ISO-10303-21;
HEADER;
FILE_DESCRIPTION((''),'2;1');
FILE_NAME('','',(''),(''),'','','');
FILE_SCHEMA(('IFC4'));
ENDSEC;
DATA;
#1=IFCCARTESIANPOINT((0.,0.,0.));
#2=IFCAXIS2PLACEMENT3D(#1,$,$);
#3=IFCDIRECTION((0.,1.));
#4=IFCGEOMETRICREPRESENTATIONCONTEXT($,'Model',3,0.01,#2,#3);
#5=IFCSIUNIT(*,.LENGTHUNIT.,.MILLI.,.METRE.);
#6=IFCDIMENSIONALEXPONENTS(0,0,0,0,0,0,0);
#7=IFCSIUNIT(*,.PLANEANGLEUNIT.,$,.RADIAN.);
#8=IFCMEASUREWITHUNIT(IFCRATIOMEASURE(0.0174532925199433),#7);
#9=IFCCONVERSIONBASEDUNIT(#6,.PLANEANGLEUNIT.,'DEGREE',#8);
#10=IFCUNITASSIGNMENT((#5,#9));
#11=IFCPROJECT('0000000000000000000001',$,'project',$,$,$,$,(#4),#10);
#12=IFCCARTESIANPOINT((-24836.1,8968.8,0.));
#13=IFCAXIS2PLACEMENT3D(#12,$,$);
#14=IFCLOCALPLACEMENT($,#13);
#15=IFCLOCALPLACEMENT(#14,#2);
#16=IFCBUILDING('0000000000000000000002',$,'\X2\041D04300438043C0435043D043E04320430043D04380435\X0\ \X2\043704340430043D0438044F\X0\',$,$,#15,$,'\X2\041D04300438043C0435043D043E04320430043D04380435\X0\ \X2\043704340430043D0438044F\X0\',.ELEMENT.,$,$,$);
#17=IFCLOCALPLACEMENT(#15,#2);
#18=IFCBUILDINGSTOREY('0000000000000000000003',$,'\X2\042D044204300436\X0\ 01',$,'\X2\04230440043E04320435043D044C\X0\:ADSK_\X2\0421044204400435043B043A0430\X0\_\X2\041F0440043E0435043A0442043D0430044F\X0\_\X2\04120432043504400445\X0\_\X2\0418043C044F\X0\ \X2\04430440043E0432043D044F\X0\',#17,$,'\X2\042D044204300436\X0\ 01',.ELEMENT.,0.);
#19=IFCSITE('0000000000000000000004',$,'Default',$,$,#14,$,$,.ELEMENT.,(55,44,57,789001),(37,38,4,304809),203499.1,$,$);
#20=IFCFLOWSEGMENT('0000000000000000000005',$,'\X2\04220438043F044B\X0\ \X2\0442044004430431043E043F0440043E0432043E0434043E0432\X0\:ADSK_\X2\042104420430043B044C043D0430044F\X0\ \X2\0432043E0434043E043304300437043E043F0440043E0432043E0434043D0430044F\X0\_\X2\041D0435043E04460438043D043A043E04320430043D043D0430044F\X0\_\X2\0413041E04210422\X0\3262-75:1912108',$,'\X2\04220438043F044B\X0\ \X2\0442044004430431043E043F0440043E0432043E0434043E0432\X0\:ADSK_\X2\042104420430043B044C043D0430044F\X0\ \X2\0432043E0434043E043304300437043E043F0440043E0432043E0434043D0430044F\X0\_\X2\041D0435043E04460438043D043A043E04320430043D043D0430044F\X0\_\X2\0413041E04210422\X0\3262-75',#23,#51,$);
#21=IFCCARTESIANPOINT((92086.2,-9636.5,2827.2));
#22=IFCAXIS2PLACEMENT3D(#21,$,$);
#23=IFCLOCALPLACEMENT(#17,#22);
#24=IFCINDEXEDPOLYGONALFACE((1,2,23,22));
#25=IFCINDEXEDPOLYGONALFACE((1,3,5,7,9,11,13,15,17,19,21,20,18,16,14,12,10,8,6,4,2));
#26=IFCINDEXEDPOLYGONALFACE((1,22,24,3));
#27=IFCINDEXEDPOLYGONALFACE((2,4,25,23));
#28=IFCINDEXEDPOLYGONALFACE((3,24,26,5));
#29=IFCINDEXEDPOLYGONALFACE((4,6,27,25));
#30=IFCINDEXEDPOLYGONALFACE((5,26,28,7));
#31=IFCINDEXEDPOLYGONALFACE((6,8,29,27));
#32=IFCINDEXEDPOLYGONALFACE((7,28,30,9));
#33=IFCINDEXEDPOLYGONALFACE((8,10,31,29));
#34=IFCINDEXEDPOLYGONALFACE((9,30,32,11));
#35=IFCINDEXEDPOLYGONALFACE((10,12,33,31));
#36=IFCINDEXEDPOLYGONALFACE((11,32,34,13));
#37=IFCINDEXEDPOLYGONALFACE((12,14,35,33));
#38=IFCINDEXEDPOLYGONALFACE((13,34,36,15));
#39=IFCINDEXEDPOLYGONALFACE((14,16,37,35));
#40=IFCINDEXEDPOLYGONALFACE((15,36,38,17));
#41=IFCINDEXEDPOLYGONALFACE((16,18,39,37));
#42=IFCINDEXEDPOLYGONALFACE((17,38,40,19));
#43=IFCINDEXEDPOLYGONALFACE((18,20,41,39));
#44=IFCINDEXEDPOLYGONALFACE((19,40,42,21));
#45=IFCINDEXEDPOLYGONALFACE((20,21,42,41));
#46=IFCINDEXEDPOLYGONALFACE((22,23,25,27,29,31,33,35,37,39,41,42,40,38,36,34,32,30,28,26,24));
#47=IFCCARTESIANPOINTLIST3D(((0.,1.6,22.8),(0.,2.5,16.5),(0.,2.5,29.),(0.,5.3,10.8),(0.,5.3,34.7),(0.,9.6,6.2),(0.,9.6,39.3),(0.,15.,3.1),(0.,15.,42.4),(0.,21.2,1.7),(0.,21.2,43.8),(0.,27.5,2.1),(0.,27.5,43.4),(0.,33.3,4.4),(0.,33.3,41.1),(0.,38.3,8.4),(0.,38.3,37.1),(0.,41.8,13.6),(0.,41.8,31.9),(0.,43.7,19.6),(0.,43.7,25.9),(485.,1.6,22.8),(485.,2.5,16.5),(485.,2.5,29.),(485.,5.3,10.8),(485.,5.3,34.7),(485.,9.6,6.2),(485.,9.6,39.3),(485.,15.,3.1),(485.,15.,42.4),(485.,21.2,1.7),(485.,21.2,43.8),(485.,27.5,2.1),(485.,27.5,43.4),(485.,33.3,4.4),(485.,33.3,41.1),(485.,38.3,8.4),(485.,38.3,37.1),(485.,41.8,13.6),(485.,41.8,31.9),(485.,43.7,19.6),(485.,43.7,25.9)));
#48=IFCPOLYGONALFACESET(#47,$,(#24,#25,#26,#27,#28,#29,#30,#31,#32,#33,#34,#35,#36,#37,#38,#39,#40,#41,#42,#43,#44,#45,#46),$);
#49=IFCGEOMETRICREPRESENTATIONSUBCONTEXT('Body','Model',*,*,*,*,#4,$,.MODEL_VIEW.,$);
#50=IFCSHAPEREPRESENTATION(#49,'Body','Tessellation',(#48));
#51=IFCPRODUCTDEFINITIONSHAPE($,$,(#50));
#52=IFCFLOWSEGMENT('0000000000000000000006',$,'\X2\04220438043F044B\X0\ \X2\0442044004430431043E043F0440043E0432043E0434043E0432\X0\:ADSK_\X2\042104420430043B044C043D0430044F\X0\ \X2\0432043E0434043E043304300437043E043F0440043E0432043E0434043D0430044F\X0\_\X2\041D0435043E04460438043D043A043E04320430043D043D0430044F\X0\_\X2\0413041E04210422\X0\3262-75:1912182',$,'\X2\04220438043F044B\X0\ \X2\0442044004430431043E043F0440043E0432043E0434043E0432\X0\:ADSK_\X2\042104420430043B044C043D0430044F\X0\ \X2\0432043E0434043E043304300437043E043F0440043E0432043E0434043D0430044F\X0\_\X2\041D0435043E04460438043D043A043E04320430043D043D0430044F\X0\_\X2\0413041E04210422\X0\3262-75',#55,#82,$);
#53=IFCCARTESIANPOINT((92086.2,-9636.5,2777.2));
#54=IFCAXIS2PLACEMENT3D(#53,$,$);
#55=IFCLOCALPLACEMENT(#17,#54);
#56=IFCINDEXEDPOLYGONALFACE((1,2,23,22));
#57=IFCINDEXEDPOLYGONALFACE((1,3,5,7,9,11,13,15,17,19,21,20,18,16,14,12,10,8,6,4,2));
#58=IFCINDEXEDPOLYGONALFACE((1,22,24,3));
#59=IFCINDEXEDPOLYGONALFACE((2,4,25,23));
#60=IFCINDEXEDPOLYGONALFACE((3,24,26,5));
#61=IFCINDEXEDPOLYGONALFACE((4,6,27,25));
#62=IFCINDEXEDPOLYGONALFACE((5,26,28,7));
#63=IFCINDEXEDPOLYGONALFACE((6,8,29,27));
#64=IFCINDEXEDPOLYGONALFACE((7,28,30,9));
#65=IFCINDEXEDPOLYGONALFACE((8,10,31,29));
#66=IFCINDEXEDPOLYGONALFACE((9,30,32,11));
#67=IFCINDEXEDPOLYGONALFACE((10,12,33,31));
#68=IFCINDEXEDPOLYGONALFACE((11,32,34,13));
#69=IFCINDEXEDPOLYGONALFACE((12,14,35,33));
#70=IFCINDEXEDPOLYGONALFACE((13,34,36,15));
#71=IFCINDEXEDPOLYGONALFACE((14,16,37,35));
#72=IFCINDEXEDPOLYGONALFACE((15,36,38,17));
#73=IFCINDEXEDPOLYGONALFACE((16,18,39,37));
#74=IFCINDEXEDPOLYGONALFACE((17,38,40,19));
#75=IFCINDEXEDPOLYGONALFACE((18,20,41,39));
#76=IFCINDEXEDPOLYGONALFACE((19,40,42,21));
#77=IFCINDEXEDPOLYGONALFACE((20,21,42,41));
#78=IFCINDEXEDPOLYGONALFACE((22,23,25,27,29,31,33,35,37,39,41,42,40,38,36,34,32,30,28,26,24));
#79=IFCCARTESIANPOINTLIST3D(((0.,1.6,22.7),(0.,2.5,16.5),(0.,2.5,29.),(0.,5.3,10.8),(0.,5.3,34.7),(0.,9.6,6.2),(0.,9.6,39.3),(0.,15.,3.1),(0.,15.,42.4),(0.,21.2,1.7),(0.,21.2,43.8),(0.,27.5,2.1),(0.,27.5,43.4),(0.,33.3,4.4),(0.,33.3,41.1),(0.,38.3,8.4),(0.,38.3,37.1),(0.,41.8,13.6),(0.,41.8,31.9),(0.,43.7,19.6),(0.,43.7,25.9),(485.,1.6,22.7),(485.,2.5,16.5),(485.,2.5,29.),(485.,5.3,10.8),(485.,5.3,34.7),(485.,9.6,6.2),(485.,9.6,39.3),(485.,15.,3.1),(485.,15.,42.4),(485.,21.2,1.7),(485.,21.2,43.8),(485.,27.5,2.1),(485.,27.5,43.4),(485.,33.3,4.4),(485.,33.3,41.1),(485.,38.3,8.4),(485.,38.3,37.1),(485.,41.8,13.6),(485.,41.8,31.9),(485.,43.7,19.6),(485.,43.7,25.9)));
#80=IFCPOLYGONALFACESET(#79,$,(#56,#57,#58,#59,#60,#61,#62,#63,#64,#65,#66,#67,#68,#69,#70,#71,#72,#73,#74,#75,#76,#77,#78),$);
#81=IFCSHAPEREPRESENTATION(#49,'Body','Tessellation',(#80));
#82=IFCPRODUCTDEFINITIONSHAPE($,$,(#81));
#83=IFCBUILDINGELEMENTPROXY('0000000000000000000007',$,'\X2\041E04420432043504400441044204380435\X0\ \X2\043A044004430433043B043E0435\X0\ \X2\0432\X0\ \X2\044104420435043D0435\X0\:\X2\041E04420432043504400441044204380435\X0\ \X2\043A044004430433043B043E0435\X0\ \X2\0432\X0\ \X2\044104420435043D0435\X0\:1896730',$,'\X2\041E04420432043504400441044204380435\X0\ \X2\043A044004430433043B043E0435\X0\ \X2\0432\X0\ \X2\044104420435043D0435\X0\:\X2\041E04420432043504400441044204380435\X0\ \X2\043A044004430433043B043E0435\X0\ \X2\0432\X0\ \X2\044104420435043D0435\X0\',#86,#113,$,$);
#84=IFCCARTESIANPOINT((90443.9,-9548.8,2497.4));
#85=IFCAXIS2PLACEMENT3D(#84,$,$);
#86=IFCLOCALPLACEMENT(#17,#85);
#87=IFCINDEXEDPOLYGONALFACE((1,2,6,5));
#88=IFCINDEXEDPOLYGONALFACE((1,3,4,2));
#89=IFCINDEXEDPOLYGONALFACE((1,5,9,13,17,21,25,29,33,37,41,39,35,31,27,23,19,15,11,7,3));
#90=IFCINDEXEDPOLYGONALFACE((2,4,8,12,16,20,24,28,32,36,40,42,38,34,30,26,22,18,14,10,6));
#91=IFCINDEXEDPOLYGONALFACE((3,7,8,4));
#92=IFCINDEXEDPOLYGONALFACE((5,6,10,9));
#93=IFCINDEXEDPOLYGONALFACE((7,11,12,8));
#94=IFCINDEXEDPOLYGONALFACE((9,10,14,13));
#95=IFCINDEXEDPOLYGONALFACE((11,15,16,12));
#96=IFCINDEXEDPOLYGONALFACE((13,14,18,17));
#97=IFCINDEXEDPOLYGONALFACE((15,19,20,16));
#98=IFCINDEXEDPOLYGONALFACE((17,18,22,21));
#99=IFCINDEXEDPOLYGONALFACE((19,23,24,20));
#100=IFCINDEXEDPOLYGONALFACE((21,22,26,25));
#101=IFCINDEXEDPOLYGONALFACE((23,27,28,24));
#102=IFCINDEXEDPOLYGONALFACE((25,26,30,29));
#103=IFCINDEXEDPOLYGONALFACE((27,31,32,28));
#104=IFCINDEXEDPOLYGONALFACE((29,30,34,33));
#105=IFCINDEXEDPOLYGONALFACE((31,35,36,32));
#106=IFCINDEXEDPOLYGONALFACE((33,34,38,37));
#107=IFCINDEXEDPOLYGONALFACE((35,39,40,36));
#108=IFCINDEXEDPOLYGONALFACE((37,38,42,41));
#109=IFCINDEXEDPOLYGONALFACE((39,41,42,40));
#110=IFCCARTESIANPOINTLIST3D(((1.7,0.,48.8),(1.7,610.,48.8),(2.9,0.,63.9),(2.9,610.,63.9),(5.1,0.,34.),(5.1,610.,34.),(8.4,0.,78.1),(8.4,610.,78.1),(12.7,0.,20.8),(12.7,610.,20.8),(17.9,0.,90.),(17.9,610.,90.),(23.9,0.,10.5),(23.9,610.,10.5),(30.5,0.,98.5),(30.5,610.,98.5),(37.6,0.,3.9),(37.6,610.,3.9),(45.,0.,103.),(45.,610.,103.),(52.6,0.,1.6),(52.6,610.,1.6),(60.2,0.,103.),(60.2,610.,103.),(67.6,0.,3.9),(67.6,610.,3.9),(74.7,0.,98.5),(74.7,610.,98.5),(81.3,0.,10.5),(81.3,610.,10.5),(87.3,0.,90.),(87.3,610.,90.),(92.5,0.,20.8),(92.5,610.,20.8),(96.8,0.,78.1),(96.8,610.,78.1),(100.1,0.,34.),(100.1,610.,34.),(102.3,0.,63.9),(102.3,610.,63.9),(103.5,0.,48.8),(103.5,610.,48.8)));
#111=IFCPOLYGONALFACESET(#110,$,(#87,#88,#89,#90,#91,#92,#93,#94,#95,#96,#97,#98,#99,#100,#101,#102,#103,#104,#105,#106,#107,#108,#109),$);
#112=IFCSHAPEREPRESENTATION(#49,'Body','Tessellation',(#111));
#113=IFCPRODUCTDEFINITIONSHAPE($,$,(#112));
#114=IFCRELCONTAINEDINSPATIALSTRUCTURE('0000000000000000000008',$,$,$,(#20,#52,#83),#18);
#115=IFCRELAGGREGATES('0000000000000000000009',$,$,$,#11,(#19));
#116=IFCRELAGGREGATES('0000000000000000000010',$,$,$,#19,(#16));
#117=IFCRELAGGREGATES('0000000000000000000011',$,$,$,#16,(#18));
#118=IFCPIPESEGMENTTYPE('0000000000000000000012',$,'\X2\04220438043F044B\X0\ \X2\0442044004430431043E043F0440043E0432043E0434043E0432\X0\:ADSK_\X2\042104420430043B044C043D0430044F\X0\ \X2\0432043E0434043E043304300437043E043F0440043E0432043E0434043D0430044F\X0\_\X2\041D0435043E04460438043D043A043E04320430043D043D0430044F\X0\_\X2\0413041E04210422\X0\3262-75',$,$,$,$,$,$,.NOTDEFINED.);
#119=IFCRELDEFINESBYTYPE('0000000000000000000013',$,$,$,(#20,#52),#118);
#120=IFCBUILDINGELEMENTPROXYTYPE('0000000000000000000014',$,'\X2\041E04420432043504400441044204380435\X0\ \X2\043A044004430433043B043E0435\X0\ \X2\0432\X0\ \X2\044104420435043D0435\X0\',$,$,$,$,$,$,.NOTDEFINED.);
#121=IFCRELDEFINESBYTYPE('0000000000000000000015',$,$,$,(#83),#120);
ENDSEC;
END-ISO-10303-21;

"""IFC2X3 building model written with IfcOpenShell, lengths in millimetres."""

from ifc_helpers import new_model, entity, si_unit, converted_unit, direction, frame, origin, origin_2d_with_axis, place, context, subcontext, project, spatial, circle, extrude, type_object, element, save


model = new_model("IFC2X3")

# Units and contexts
model_context = context("Model", 3, precision=0.01, world=origin(), true_north=direction((0.0, 1.0)))
body_context = subcontext(model_context, "Body", "Model", "MODEL_VIEW")
ifc_project = project(units=[si_unit("LENGTHUNIT", "METRE", prefix="MILLI"), converted_unit("PLANEANGLEUNIT", "DEGREE", entity("IfcRatioMeasure", 0.0174532925199433), si_unit("PLANEANGLEUNIT", "RADIAN"), dimensions=[0, 0, 0, 0, 0, 0, 0])], contexts=[model_context])

# Site, building, storey
site_placement = place(None, frame((-24836.1, 8968.8, 0.0)))
site = spatial("IfcSite", under=ifc_project, at=site_placement, Name="Default", CompositionType="ELEMENT", RefLatitude=(55, 44, 57, 789001), RefLongitude=(37, 38, 4, 304809), RefElevation=203499.1)
building_placement = place(site_placement, origin())
building = spatial("IfcBuilding", under=site, at=building_placement, Name="Наименование здания", LongName="Наименование здания", CompositionType="ELEMENT")
storey_placement = place(building_placement, origin())
storey = spatial("IfcBuildingStorey", under=building, at=storey_placement, Name="Этаж 01", ObjectType="Уровень:ADSK_Стрелка_Проектная_Вверх_Имя уровня", LongName="Этаж 01", CompositionType="ELEMENT", Elevation=0.0)

# Flow segments
pipe_segment_type_1 = type_object("IfcPipeSegmentType", Name="Типы трубопроводов:ADSK_Стальная водогазопроводная_Неоцинкованная_ГОСТ3262-75", PredefinedType="NOTDEFINED")
for number, where, name in (
    (1, (92086.2, -9636.5, 2827.2), "Типы трубопроводов:ADSK_Стальная водогазопроводная_Неоцинкованная_ГОСТ3262-75:1912108"),
    (2, (92086.2, -9636.5, 2777.2), "Типы трубопроводов:ADSK_Стальная водогазопроводная_Неоцинкованная_ГОСТ3262-75:1912182"),
):
    element("IfcFlowSegment", number, at=place(storey_placement, frame(where)), inside=storey, type_object=pipe_segment_type_1, Name=name, ObjectType="Типы трубопроводов:ADSK_Стальная водогазопроводная_Неоцинкованная_ГОСТ3262-75", context=body_context, shape_type="SweptSolid", body=[
        extrude(circle(Radius=21.1, at=origin_2d_with_axis()), frame((0.0, 22.8, 22.8), z_axis=(1.0, 0.0, 0.0), x_axis=(0.0, -1.0, 0.0)), (0.0, 0.0, 1.0), 485.0),
    ])

# Building element proxy
building_element_proxy_type_1 = type_object("IfcBuildingElementProxyType", Name="Отверстие круглое в стене", PredefinedType="NOTDEFINED")
proxy_1_placement = place(storey_placement, frame((90443.9, -9548.8, 2497.4)))
element("IfcBuildingElementProxy", 3, at=proxy_1_placement, inside=storey, type_object=building_element_proxy_type_1, Name="Отверстие круглое в стене:Отверстие круглое в стене:1896730", ObjectType="Отверстие круглое в стене:Отверстие круглое в стене", context=body_context, shape_type="SweptSolid", body=[
    extrude(circle(Radius=51.0, at=origin_2d_with_axis()), frame((52.6, 0.0, 52.6), z_axis=(0.0, 1.0, 0.0), x_axis=(0.0, 0.0, -1.0)), (0.0, 0.0, 1.0), 610.0),
])

save(model, "model.ifc")
